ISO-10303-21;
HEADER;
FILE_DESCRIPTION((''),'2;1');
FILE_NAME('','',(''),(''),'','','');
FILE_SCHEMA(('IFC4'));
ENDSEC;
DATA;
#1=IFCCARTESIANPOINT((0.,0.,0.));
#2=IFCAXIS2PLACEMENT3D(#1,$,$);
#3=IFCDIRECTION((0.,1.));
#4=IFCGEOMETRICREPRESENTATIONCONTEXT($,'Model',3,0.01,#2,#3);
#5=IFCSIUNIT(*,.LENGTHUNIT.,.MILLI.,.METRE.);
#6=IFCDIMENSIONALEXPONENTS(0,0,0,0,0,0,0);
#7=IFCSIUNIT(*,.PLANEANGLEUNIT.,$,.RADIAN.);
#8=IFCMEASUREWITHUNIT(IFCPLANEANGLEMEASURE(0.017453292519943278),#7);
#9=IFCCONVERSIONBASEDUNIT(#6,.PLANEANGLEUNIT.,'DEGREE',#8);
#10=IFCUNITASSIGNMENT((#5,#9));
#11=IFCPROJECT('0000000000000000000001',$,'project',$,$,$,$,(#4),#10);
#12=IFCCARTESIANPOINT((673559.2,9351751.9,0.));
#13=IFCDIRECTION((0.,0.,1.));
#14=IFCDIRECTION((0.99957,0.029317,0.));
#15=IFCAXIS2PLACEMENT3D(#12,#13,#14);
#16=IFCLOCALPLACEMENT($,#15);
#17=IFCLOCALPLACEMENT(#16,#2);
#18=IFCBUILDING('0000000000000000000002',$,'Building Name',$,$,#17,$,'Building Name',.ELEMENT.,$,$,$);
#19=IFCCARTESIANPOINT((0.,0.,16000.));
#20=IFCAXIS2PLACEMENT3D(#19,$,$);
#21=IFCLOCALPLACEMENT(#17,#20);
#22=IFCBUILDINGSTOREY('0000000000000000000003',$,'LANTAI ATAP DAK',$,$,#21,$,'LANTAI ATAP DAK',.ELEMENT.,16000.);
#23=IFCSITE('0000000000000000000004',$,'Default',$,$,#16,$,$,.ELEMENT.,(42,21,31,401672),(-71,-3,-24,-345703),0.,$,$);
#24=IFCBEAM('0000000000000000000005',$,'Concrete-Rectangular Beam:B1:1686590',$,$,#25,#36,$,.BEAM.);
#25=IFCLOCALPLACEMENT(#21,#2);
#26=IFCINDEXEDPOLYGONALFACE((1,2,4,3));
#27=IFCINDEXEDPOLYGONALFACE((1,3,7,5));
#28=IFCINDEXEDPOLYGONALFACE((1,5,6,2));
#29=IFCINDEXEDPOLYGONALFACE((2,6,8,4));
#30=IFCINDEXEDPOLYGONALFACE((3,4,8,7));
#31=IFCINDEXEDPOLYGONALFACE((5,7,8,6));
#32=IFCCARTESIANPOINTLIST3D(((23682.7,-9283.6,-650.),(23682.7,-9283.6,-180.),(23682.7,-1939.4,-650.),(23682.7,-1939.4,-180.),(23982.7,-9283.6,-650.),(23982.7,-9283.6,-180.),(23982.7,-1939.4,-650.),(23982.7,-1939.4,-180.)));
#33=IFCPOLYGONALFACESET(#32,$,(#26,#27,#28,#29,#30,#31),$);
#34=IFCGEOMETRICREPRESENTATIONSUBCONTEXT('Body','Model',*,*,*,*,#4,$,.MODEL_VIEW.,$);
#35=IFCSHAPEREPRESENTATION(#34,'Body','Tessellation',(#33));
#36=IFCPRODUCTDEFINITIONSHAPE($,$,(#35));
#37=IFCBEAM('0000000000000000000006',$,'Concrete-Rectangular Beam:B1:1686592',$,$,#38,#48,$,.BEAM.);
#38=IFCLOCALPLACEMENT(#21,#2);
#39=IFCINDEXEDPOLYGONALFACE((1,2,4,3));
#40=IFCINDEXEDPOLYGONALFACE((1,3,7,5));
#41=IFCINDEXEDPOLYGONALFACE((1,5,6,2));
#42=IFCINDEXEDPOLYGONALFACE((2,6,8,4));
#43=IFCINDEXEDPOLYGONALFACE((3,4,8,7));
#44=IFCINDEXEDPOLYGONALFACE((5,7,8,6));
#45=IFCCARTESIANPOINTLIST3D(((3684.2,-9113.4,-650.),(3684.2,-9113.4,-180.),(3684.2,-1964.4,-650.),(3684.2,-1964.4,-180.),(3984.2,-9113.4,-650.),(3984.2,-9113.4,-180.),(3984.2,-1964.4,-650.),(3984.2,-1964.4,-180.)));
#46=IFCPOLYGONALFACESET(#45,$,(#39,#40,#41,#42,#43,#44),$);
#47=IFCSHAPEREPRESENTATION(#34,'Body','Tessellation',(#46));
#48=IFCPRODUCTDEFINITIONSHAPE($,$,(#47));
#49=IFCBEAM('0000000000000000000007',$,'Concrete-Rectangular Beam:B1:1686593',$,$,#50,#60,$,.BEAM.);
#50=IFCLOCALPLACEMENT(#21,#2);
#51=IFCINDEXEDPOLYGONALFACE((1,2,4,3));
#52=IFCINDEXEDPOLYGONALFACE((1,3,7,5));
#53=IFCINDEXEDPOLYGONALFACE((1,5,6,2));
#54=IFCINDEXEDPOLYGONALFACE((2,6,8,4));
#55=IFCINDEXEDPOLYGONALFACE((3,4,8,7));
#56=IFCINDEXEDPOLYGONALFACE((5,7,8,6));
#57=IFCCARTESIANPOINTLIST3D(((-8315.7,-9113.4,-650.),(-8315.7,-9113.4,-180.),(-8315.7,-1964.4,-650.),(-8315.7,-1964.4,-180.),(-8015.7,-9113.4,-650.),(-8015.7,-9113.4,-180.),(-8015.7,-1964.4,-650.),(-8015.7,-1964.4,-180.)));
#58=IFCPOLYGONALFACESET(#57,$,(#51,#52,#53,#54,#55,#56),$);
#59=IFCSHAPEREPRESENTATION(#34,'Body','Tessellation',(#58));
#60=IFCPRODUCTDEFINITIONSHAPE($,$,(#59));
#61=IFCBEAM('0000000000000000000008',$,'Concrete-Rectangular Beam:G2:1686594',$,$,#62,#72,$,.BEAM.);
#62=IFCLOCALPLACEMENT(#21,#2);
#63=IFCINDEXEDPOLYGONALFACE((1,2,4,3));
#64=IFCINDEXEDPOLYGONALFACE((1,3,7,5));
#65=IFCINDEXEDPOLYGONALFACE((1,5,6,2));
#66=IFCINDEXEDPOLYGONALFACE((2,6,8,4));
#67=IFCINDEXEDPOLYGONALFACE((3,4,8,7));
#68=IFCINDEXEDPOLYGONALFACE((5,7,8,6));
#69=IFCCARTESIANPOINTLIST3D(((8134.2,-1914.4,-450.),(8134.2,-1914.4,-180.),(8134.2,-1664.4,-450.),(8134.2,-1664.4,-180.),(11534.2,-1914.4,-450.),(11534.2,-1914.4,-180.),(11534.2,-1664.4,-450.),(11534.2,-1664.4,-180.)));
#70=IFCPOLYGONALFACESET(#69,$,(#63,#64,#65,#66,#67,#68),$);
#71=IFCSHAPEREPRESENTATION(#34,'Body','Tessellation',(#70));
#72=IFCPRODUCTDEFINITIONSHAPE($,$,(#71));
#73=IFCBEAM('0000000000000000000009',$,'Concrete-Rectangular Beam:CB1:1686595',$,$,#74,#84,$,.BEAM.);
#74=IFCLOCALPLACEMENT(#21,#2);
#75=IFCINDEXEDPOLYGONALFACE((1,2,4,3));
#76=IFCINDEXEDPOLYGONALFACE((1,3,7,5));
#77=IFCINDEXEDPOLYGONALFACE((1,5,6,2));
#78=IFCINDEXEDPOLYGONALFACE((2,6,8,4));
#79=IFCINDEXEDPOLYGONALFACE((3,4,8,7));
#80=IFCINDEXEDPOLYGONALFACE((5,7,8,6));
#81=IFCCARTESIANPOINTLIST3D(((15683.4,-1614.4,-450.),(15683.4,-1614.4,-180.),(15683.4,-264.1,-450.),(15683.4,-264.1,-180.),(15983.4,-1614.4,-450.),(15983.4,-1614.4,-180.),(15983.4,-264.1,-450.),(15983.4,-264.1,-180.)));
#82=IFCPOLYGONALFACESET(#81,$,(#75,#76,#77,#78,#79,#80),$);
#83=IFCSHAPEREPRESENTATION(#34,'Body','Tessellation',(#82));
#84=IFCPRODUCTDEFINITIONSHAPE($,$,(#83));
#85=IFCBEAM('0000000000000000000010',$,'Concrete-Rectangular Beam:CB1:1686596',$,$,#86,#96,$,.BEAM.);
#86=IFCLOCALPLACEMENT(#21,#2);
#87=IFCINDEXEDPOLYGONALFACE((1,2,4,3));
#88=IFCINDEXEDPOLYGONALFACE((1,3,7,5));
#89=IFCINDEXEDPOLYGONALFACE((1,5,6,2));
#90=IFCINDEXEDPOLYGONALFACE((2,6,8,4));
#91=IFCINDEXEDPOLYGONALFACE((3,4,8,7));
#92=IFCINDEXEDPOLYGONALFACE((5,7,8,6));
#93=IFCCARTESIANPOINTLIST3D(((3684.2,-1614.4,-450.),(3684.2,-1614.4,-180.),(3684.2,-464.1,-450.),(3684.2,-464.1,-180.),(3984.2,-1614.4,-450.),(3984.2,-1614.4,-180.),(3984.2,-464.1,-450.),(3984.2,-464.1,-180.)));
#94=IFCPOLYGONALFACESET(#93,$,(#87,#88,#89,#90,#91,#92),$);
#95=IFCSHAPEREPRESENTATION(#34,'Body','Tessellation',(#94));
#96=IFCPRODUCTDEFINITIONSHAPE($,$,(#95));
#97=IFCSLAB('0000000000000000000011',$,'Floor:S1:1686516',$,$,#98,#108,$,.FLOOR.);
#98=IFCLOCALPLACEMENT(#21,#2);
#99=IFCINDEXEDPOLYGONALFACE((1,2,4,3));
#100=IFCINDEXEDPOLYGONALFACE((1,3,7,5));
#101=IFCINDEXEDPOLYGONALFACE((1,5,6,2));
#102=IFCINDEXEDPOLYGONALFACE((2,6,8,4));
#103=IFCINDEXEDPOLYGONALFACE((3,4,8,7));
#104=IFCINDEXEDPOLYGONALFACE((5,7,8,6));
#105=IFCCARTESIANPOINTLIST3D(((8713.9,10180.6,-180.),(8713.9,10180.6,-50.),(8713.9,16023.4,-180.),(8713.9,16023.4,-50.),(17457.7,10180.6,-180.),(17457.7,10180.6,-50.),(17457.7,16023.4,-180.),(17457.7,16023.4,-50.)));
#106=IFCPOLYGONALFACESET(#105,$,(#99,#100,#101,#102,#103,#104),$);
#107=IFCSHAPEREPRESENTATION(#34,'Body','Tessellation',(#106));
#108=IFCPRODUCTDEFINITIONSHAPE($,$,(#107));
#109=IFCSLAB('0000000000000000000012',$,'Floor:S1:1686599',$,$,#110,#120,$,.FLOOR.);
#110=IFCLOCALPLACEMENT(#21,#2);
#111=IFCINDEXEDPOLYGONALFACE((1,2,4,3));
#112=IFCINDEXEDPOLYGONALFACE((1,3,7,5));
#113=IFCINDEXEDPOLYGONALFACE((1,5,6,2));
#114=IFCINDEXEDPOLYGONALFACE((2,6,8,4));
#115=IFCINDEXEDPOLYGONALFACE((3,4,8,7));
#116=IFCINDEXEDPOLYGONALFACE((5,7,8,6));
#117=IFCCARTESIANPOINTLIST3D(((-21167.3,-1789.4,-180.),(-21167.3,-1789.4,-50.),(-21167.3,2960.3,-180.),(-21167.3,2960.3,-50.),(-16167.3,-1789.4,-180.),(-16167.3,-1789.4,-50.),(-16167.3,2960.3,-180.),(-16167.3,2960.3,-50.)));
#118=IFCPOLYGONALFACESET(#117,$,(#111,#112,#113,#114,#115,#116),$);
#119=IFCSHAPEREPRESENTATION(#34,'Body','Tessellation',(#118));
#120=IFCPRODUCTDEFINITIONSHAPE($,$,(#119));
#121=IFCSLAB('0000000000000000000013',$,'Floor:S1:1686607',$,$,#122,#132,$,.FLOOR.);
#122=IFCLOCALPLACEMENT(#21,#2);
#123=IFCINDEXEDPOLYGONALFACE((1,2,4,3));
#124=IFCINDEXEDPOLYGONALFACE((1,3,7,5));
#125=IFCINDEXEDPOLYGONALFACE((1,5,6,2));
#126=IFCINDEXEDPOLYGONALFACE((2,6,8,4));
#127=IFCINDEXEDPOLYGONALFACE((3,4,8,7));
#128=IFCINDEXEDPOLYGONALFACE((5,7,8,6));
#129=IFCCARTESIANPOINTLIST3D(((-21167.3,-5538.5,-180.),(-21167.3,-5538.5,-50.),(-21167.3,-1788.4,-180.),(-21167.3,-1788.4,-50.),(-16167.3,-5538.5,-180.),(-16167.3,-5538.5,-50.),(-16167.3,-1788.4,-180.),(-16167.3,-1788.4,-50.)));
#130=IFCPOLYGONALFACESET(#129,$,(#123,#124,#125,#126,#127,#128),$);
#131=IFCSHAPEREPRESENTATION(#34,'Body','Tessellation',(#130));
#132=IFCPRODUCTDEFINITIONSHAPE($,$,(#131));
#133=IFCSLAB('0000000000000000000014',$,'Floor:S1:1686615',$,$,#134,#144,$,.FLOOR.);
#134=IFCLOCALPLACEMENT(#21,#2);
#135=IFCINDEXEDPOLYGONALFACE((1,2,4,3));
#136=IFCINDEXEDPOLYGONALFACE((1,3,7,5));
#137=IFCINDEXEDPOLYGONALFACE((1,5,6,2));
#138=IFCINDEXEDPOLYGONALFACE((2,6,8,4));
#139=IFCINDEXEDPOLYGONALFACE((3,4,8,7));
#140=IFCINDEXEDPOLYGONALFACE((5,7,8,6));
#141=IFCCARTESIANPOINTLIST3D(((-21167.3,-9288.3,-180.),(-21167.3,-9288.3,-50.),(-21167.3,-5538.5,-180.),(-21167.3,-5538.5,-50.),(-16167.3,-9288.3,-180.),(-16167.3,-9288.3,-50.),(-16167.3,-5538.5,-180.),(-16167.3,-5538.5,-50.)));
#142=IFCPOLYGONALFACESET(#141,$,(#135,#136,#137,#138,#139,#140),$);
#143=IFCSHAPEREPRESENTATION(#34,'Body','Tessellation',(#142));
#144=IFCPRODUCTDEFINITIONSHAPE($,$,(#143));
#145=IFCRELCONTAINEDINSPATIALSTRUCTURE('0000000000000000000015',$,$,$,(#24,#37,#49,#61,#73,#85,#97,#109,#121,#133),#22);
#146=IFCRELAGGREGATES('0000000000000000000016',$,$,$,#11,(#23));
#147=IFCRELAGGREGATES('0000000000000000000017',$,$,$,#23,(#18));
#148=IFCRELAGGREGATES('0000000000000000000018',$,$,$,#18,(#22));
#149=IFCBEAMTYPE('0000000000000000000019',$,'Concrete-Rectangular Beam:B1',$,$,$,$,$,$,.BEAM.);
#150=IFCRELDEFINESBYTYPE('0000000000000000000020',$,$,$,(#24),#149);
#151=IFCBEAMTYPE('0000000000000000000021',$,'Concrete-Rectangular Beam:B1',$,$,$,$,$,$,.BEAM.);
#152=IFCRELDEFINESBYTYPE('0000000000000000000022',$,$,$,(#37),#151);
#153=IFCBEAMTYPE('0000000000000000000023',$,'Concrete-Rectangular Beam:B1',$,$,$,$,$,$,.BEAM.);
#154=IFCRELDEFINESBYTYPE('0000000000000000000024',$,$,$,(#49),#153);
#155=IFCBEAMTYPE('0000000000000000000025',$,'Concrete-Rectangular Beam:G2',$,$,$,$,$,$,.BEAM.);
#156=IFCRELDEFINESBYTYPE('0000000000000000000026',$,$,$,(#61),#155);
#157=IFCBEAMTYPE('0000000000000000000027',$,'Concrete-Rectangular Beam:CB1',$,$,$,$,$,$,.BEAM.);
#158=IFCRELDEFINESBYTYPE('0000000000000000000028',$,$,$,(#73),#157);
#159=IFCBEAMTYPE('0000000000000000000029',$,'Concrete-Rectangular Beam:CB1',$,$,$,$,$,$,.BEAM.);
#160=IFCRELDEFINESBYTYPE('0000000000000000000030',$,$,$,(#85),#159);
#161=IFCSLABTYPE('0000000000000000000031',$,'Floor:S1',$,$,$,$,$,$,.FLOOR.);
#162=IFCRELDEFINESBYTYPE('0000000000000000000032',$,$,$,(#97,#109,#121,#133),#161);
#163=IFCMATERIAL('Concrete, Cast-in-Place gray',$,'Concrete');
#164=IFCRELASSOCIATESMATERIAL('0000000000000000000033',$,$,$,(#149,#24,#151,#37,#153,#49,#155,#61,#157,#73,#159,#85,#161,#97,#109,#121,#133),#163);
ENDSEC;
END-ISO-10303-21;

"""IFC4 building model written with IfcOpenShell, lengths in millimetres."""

from ifc_helpers import new_model, entity, si_unit, converted_unit, direction, frame, origin, place, context, subcontext, project, spatial, indexed_curve, outline, extrude, source, transform, mapped, material, type_object, type_shapes, element, save


model = new_model("IFC4")

# Units and contexts
model_context = context("Model", 3, precision=0.01, world=origin(), true_north=direction((0.0, 1.0)))
body_context = subcontext(model_context, "Body", "Model", "MODEL_VIEW")
ifc_project = project(units=[si_unit("LENGTHUNIT", "METRE", prefix="MILLI"), converted_unit("PLANEANGLEUNIT", "DEGREE", entity("IfcPlaneAngleMeasure", 0.017453292519943278), si_unit("PLANEANGLEUNIT", "RADIAN"), dimensions=[0, 0, 0, 0, 0, 0, 0])], contexts=[model_context])

# Site, building, storey
site_placement = place(None, frame((673559.2, 9351751.9, 0.0), z_axis=(0.0, 0.0, 1.0), x_axis=(0.99957, 0.029317, 0.0)))
site = spatial("IfcSite", under=ifc_project, at=site_placement, Name="Default", CompositionType="ELEMENT", RefLatitude=(42, 21, 31, 401672), RefLongitude=(-71, -3, -24, -345703), RefElevation=0.0)
building_placement = place(site_placement, origin())
building = spatial("IfcBuilding", under=site, at=building_placement, Name="Building Name", LongName="Building Name", CompositionType="ELEMENT")
storey_placement = place(building_placement, frame((0.0, 0.0, 16000.0)))
storey = spatial("IfcBuildingStorey", under=building, at=storey_placement, Name="LANTAI ATAP DAK", LongName="LANTAI ATAP DAK", CompositionType="ELEMENT", Elevation=16000.0)

# Beams
ifc_material = material(Name="Concrete, Cast-in-Place gray", Category="Concrete")
beam_type_1 = type_object("IfcBeamType", Name="Concrete-Rectangular Beam:B1", PredefinedType="BEAM", material=ifc_material)
shared_shape_1 = source(origin(), body_context, "Body", "SweptSolid", [
    extrude(outline(indexed_curve([(-150.0, -235.0), (150.0, -235.0), (150.0, 235.0), (-150.0, 235.0), (-150.0, -235.0)], self_intersect=False)), frame((23832.7, -9283.6, 15585.0), z_axis=(0.0, 1.0, 0.0), x_axis=(-1.0, 0.0, 0.0)), (0.0, 0.0, 1.0), 7344.1),
])
type_shapes(beam_type_1, [shared_shape_1])
beam_1_placement = place(storey_placement, frame((0.0, 0.0, -16000.0)))
element("IfcBeam", 1, at=beam_1_placement, inside=storey, type_object=beam_type_1, material=ifc_material, Name="Concrete-Rectangular Beam:B1:1686590", PredefinedType="BEAM", context=body_context, shape_type="MappedRepresentation", body=[
    mapped(shared_shape_1, transform((0.0, 0.0, 0.0), scale=1.0)),
])
beam_type_2 = type_object("IfcBeamType", Name="Concrete-Rectangular Beam:B1", PredefinedType="BEAM", material=ifc_material)
shared_shape_2 = source(origin(), body_context, "Body", "SweptSolid", [
    extrude(outline(indexed_curve([(-150.0, -235.0), (150.0, -235.0), (150.0, 235.0), (-150.0, 235.0), (-150.0, -235.0)], self_intersect=False)), frame((3834.2, -9113.4, 15585.0), z_axis=(0.0, 1.0, 0.0), x_axis=(-1.0, 0.0, 0.0)), (0.0, 0.0, 1.0), 7149.0),
])
type_shapes(beam_type_2, [shared_shape_2])
beam_2_placement = place(storey_placement, frame((0.0, 0.0, -16000.0)))
element("IfcBeam", 2, at=beam_2_placement, inside=storey, type_object=beam_type_2, material=ifc_material, Name="Concrete-Rectangular Beam:B1:1686592", PredefinedType="BEAM", context=body_context, shape_type="MappedRepresentation", body=[
    mapped(shared_shape_2, transform((0.0, 0.0, 0.0), scale=1.0)),
])
beam_type_3 = type_object("IfcBeamType", Name="Concrete-Rectangular Beam:B1", PredefinedType="BEAM", material=ifc_material)
shared_shape_3 = source(origin(), body_context, "Body", "SweptSolid", [
    extrude(outline(indexed_curve([(-150.0, -235.0), (150.0, -235.0), (150.0, 235.0), (-150.0, 235.0), (-150.0, -235.0)], self_intersect=False)), frame((-8165.7, -9113.4, 15585.0), z_axis=(0.0, 1.0, 0.0), x_axis=(-1.0, 0.0, 0.0)), (0.0, 0.0, 1.0), 7149.0),
])
type_shapes(beam_type_3, [shared_shape_3])
beam_3_placement = place(storey_placement, frame((0.0, 0.0, -16000.0)))
element("IfcBeam", 3, at=beam_3_placement, inside=storey, type_object=beam_type_3, material=ifc_material, Name="Concrete-Rectangular Beam:B1:1686593", PredefinedType="BEAM", context=body_context, shape_type="MappedRepresentation", body=[
    mapped(shared_shape_3, transform((0.0, 0.0, 0.0), scale=1.0)),
])
beam_type_4 = type_object("IfcBeamType", Name="Concrete-Rectangular Beam:G2", PredefinedType="BEAM", material=ifc_material)
shared_shape_4 = source(origin(), body_context, "Body", "SweptSolid", [
    extrude(outline(indexed_curve([(-135.0, -125.0), (135.0, -125.0), (135.0, 125.0), (-135.0, 125.0), (-135.0, -125.0)], self_intersect=False)), frame((8134.2, -1789.4, 15685.0), z_axis=(1.0, 0.0, 0.0), x_axis=(0.0, 0.0, -1.0)), (0.0, 0.0, 1.0), 3400.0),
])
type_shapes(beam_type_4, [shared_shape_4])
beam_4_placement = place(storey_placement, frame((0.0, 0.0, -16000.0)))
element("IfcBeam", 4, at=beam_4_placement, inside=storey, type_object=beam_type_4, material=ifc_material, Name="Concrete-Rectangular Beam:G2:1686594", PredefinedType="BEAM", context=body_context, shape_type="MappedRepresentation", body=[
    mapped(shared_shape_4, transform((0.0, 0.0, 0.0), scale=1.0)),
])
beam_type_5 = type_object("IfcBeamType", Name="Concrete-Rectangular Beam:CB1", PredefinedType="BEAM", material=ifc_material)
shared_shape_5 = source(origin(), body_context, "Body", "SweptSolid", [
    extrude(outline(indexed_curve([(-150.0, -135.0), (150.0, -135.0), (150.0, 135.0), (-150.0, 135.0), (-150.0, -135.0)], self_intersect=False)), frame((15833.4, -1614.4, 15685.0), z_axis=(0.0, 1.0, 0.0), x_axis=(-1.0, 0.0, 0.0)), (0.0, 0.0, 1.0), 1350.4),
])
type_shapes(beam_type_5, [shared_shape_5])
beam_5_placement = place(storey_placement, frame((0.0, 0.0, -16000.0)))
element("IfcBeam", 5, at=beam_5_placement, inside=storey, type_object=beam_type_5, material=ifc_material, Name="Concrete-Rectangular Beam:CB1:1686595", PredefinedType="BEAM", context=body_context, shape_type="MappedRepresentation", body=[
    mapped(shared_shape_5, transform((0.0, 0.0, 0.0), scale=1.0)),
])
beam_type_6 = type_object("IfcBeamType", Name="Concrete-Rectangular Beam:CB1", PredefinedType="BEAM", material=ifc_material)
shared_shape_6 = source(origin(), body_context, "Body", "SweptSolid", [
    extrude(outline(indexed_curve([(-150.0, -135.0), (150.0, -135.0), (150.0, 135.0), (-150.0, 135.0), (-150.0, -135.0)], self_intersect=False)), frame((3834.2, -1614.4, 15685.0), z_axis=(0.0, 1.0, 0.0), x_axis=(-1.0, 0.0, 0.0)), (0.0, 0.0, 1.0), 1150.4),
])
type_shapes(beam_type_6, [shared_shape_6])
beam_6_placement = place(storey_placement, frame((0.0, 0.0, -16000.0)))
element("IfcBeam", 6, at=beam_6_placement, inside=storey, type_object=beam_type_6, material=ifc_material, Name="Concrete-Rectangular Beam:CB1:1686596", PredefinedType="BEAM", context=body_context, shape_type="MappedRepresentation", body=[
    mapped(shared_shape_6, transform((0.0, 0.0, 0.0), scale=1.0)),
])

# Slabs
slab_type = type_object("IfcSlabType", Name="Floor:S1", PredefinedType="FLOOR", material=ifc_material)
slab_1_placement = place(storey_placement, origin())
element("IfcSlab", 7, at=slab_1_placement, inside=storey, type_object=slab_type, material=ifc_material, Name="Floor:S1:1686516", PredefinedType="FLOOR", context=body_context, shape_type="SweptSolid", body=[
    extrude(outline(indexed_curve([(-2921.4, -4371.9), (2921.4, -4371.9), (2921.4, 4371.9), (-2921.4, 4371.9), (-2921.4, -4371.9)], self_intersect=False)), frame((13085.8, 13102.0, -50.0), z_axis=(0.0, 0.0, -1.0), x_axis=(0.0, 1.0, 0.0)), (0.0, 0.0, 1.0), 130.0),
])
slab_2_placement = place(storey_placement, origin())
element("IfcSlab", 8, at=slab_2_placement, inside=storey, type_object=slab_type, material=ifc_material, Name="Floor:S1:1686599", PredefinedType="FLOOR", context=body_context, shape_type="SweptSolid", body=[
    extrude(outline(indexed_curve([(-2374.9, -2500.0), (2374.9, -2500.0), (2374.9, 2500.0), (-2374.9, 2500.0), (-2374.9, -2500.0)], self_intersect=False)), frame((-18667.3, 585.4, -50.0), z_axis=(0.0, 0.0, -1.0), x_axis=(0.0, 1.0, 0.0)), (0.0, 0.0, 1.0), 130.0),
])
slab_3_placement = place(storey_placement, origin())
element("IfcSlab", 9, at=slab_3_placement, inside=storey, type_object=slab_type, material=ifc_material, Name="Floor:S1:1686607", PredefinedType="FLOOR", context=body_context, shape_type="SweptSolid", body=[
    extrude(outline(indexed_curve([(-1875.1, -2500.0), (1875.1, -2500.0), (1875.1, 2500.0), (-1875.1, 2500.0), (-1875.1, -2500.0)], self_intersect=False)), frame((-18667.3, -3663.5, -50.0), z_axis=(0.0, 0.0, -1.0), x_axis=(0.0, 1.0, 0.0)), (0.0, 0.0, 1.0), 130.0),
])
slab_4_placement = place(storey_placement, origin())
element("IfcSlab", 10, at=slab_4_placement, inside=storey, type_object=slab_type, material=ifc_material, Name="Floor:S1:1686615", PredefinedType="FLOOR", context=body_context, shape_type="SweptSolid", body=[
    extrude(outline(indexed_curve([(-1874.9, -2500.0), (1874.9, -2500.0), (1874.9, 2500.0), (-1874.9, 2500.0), (-1874.9, -2500.0)], self_intersect=False)), frame((-18667.3, -7413.4, -50.0), z_axis=(0.0, 0.0, -1.0), x_axis=(0.0, 1.0, 0.0)), (0.0, 0.0, 1.0), 130.0),
])

save(model, "model.ifc")
